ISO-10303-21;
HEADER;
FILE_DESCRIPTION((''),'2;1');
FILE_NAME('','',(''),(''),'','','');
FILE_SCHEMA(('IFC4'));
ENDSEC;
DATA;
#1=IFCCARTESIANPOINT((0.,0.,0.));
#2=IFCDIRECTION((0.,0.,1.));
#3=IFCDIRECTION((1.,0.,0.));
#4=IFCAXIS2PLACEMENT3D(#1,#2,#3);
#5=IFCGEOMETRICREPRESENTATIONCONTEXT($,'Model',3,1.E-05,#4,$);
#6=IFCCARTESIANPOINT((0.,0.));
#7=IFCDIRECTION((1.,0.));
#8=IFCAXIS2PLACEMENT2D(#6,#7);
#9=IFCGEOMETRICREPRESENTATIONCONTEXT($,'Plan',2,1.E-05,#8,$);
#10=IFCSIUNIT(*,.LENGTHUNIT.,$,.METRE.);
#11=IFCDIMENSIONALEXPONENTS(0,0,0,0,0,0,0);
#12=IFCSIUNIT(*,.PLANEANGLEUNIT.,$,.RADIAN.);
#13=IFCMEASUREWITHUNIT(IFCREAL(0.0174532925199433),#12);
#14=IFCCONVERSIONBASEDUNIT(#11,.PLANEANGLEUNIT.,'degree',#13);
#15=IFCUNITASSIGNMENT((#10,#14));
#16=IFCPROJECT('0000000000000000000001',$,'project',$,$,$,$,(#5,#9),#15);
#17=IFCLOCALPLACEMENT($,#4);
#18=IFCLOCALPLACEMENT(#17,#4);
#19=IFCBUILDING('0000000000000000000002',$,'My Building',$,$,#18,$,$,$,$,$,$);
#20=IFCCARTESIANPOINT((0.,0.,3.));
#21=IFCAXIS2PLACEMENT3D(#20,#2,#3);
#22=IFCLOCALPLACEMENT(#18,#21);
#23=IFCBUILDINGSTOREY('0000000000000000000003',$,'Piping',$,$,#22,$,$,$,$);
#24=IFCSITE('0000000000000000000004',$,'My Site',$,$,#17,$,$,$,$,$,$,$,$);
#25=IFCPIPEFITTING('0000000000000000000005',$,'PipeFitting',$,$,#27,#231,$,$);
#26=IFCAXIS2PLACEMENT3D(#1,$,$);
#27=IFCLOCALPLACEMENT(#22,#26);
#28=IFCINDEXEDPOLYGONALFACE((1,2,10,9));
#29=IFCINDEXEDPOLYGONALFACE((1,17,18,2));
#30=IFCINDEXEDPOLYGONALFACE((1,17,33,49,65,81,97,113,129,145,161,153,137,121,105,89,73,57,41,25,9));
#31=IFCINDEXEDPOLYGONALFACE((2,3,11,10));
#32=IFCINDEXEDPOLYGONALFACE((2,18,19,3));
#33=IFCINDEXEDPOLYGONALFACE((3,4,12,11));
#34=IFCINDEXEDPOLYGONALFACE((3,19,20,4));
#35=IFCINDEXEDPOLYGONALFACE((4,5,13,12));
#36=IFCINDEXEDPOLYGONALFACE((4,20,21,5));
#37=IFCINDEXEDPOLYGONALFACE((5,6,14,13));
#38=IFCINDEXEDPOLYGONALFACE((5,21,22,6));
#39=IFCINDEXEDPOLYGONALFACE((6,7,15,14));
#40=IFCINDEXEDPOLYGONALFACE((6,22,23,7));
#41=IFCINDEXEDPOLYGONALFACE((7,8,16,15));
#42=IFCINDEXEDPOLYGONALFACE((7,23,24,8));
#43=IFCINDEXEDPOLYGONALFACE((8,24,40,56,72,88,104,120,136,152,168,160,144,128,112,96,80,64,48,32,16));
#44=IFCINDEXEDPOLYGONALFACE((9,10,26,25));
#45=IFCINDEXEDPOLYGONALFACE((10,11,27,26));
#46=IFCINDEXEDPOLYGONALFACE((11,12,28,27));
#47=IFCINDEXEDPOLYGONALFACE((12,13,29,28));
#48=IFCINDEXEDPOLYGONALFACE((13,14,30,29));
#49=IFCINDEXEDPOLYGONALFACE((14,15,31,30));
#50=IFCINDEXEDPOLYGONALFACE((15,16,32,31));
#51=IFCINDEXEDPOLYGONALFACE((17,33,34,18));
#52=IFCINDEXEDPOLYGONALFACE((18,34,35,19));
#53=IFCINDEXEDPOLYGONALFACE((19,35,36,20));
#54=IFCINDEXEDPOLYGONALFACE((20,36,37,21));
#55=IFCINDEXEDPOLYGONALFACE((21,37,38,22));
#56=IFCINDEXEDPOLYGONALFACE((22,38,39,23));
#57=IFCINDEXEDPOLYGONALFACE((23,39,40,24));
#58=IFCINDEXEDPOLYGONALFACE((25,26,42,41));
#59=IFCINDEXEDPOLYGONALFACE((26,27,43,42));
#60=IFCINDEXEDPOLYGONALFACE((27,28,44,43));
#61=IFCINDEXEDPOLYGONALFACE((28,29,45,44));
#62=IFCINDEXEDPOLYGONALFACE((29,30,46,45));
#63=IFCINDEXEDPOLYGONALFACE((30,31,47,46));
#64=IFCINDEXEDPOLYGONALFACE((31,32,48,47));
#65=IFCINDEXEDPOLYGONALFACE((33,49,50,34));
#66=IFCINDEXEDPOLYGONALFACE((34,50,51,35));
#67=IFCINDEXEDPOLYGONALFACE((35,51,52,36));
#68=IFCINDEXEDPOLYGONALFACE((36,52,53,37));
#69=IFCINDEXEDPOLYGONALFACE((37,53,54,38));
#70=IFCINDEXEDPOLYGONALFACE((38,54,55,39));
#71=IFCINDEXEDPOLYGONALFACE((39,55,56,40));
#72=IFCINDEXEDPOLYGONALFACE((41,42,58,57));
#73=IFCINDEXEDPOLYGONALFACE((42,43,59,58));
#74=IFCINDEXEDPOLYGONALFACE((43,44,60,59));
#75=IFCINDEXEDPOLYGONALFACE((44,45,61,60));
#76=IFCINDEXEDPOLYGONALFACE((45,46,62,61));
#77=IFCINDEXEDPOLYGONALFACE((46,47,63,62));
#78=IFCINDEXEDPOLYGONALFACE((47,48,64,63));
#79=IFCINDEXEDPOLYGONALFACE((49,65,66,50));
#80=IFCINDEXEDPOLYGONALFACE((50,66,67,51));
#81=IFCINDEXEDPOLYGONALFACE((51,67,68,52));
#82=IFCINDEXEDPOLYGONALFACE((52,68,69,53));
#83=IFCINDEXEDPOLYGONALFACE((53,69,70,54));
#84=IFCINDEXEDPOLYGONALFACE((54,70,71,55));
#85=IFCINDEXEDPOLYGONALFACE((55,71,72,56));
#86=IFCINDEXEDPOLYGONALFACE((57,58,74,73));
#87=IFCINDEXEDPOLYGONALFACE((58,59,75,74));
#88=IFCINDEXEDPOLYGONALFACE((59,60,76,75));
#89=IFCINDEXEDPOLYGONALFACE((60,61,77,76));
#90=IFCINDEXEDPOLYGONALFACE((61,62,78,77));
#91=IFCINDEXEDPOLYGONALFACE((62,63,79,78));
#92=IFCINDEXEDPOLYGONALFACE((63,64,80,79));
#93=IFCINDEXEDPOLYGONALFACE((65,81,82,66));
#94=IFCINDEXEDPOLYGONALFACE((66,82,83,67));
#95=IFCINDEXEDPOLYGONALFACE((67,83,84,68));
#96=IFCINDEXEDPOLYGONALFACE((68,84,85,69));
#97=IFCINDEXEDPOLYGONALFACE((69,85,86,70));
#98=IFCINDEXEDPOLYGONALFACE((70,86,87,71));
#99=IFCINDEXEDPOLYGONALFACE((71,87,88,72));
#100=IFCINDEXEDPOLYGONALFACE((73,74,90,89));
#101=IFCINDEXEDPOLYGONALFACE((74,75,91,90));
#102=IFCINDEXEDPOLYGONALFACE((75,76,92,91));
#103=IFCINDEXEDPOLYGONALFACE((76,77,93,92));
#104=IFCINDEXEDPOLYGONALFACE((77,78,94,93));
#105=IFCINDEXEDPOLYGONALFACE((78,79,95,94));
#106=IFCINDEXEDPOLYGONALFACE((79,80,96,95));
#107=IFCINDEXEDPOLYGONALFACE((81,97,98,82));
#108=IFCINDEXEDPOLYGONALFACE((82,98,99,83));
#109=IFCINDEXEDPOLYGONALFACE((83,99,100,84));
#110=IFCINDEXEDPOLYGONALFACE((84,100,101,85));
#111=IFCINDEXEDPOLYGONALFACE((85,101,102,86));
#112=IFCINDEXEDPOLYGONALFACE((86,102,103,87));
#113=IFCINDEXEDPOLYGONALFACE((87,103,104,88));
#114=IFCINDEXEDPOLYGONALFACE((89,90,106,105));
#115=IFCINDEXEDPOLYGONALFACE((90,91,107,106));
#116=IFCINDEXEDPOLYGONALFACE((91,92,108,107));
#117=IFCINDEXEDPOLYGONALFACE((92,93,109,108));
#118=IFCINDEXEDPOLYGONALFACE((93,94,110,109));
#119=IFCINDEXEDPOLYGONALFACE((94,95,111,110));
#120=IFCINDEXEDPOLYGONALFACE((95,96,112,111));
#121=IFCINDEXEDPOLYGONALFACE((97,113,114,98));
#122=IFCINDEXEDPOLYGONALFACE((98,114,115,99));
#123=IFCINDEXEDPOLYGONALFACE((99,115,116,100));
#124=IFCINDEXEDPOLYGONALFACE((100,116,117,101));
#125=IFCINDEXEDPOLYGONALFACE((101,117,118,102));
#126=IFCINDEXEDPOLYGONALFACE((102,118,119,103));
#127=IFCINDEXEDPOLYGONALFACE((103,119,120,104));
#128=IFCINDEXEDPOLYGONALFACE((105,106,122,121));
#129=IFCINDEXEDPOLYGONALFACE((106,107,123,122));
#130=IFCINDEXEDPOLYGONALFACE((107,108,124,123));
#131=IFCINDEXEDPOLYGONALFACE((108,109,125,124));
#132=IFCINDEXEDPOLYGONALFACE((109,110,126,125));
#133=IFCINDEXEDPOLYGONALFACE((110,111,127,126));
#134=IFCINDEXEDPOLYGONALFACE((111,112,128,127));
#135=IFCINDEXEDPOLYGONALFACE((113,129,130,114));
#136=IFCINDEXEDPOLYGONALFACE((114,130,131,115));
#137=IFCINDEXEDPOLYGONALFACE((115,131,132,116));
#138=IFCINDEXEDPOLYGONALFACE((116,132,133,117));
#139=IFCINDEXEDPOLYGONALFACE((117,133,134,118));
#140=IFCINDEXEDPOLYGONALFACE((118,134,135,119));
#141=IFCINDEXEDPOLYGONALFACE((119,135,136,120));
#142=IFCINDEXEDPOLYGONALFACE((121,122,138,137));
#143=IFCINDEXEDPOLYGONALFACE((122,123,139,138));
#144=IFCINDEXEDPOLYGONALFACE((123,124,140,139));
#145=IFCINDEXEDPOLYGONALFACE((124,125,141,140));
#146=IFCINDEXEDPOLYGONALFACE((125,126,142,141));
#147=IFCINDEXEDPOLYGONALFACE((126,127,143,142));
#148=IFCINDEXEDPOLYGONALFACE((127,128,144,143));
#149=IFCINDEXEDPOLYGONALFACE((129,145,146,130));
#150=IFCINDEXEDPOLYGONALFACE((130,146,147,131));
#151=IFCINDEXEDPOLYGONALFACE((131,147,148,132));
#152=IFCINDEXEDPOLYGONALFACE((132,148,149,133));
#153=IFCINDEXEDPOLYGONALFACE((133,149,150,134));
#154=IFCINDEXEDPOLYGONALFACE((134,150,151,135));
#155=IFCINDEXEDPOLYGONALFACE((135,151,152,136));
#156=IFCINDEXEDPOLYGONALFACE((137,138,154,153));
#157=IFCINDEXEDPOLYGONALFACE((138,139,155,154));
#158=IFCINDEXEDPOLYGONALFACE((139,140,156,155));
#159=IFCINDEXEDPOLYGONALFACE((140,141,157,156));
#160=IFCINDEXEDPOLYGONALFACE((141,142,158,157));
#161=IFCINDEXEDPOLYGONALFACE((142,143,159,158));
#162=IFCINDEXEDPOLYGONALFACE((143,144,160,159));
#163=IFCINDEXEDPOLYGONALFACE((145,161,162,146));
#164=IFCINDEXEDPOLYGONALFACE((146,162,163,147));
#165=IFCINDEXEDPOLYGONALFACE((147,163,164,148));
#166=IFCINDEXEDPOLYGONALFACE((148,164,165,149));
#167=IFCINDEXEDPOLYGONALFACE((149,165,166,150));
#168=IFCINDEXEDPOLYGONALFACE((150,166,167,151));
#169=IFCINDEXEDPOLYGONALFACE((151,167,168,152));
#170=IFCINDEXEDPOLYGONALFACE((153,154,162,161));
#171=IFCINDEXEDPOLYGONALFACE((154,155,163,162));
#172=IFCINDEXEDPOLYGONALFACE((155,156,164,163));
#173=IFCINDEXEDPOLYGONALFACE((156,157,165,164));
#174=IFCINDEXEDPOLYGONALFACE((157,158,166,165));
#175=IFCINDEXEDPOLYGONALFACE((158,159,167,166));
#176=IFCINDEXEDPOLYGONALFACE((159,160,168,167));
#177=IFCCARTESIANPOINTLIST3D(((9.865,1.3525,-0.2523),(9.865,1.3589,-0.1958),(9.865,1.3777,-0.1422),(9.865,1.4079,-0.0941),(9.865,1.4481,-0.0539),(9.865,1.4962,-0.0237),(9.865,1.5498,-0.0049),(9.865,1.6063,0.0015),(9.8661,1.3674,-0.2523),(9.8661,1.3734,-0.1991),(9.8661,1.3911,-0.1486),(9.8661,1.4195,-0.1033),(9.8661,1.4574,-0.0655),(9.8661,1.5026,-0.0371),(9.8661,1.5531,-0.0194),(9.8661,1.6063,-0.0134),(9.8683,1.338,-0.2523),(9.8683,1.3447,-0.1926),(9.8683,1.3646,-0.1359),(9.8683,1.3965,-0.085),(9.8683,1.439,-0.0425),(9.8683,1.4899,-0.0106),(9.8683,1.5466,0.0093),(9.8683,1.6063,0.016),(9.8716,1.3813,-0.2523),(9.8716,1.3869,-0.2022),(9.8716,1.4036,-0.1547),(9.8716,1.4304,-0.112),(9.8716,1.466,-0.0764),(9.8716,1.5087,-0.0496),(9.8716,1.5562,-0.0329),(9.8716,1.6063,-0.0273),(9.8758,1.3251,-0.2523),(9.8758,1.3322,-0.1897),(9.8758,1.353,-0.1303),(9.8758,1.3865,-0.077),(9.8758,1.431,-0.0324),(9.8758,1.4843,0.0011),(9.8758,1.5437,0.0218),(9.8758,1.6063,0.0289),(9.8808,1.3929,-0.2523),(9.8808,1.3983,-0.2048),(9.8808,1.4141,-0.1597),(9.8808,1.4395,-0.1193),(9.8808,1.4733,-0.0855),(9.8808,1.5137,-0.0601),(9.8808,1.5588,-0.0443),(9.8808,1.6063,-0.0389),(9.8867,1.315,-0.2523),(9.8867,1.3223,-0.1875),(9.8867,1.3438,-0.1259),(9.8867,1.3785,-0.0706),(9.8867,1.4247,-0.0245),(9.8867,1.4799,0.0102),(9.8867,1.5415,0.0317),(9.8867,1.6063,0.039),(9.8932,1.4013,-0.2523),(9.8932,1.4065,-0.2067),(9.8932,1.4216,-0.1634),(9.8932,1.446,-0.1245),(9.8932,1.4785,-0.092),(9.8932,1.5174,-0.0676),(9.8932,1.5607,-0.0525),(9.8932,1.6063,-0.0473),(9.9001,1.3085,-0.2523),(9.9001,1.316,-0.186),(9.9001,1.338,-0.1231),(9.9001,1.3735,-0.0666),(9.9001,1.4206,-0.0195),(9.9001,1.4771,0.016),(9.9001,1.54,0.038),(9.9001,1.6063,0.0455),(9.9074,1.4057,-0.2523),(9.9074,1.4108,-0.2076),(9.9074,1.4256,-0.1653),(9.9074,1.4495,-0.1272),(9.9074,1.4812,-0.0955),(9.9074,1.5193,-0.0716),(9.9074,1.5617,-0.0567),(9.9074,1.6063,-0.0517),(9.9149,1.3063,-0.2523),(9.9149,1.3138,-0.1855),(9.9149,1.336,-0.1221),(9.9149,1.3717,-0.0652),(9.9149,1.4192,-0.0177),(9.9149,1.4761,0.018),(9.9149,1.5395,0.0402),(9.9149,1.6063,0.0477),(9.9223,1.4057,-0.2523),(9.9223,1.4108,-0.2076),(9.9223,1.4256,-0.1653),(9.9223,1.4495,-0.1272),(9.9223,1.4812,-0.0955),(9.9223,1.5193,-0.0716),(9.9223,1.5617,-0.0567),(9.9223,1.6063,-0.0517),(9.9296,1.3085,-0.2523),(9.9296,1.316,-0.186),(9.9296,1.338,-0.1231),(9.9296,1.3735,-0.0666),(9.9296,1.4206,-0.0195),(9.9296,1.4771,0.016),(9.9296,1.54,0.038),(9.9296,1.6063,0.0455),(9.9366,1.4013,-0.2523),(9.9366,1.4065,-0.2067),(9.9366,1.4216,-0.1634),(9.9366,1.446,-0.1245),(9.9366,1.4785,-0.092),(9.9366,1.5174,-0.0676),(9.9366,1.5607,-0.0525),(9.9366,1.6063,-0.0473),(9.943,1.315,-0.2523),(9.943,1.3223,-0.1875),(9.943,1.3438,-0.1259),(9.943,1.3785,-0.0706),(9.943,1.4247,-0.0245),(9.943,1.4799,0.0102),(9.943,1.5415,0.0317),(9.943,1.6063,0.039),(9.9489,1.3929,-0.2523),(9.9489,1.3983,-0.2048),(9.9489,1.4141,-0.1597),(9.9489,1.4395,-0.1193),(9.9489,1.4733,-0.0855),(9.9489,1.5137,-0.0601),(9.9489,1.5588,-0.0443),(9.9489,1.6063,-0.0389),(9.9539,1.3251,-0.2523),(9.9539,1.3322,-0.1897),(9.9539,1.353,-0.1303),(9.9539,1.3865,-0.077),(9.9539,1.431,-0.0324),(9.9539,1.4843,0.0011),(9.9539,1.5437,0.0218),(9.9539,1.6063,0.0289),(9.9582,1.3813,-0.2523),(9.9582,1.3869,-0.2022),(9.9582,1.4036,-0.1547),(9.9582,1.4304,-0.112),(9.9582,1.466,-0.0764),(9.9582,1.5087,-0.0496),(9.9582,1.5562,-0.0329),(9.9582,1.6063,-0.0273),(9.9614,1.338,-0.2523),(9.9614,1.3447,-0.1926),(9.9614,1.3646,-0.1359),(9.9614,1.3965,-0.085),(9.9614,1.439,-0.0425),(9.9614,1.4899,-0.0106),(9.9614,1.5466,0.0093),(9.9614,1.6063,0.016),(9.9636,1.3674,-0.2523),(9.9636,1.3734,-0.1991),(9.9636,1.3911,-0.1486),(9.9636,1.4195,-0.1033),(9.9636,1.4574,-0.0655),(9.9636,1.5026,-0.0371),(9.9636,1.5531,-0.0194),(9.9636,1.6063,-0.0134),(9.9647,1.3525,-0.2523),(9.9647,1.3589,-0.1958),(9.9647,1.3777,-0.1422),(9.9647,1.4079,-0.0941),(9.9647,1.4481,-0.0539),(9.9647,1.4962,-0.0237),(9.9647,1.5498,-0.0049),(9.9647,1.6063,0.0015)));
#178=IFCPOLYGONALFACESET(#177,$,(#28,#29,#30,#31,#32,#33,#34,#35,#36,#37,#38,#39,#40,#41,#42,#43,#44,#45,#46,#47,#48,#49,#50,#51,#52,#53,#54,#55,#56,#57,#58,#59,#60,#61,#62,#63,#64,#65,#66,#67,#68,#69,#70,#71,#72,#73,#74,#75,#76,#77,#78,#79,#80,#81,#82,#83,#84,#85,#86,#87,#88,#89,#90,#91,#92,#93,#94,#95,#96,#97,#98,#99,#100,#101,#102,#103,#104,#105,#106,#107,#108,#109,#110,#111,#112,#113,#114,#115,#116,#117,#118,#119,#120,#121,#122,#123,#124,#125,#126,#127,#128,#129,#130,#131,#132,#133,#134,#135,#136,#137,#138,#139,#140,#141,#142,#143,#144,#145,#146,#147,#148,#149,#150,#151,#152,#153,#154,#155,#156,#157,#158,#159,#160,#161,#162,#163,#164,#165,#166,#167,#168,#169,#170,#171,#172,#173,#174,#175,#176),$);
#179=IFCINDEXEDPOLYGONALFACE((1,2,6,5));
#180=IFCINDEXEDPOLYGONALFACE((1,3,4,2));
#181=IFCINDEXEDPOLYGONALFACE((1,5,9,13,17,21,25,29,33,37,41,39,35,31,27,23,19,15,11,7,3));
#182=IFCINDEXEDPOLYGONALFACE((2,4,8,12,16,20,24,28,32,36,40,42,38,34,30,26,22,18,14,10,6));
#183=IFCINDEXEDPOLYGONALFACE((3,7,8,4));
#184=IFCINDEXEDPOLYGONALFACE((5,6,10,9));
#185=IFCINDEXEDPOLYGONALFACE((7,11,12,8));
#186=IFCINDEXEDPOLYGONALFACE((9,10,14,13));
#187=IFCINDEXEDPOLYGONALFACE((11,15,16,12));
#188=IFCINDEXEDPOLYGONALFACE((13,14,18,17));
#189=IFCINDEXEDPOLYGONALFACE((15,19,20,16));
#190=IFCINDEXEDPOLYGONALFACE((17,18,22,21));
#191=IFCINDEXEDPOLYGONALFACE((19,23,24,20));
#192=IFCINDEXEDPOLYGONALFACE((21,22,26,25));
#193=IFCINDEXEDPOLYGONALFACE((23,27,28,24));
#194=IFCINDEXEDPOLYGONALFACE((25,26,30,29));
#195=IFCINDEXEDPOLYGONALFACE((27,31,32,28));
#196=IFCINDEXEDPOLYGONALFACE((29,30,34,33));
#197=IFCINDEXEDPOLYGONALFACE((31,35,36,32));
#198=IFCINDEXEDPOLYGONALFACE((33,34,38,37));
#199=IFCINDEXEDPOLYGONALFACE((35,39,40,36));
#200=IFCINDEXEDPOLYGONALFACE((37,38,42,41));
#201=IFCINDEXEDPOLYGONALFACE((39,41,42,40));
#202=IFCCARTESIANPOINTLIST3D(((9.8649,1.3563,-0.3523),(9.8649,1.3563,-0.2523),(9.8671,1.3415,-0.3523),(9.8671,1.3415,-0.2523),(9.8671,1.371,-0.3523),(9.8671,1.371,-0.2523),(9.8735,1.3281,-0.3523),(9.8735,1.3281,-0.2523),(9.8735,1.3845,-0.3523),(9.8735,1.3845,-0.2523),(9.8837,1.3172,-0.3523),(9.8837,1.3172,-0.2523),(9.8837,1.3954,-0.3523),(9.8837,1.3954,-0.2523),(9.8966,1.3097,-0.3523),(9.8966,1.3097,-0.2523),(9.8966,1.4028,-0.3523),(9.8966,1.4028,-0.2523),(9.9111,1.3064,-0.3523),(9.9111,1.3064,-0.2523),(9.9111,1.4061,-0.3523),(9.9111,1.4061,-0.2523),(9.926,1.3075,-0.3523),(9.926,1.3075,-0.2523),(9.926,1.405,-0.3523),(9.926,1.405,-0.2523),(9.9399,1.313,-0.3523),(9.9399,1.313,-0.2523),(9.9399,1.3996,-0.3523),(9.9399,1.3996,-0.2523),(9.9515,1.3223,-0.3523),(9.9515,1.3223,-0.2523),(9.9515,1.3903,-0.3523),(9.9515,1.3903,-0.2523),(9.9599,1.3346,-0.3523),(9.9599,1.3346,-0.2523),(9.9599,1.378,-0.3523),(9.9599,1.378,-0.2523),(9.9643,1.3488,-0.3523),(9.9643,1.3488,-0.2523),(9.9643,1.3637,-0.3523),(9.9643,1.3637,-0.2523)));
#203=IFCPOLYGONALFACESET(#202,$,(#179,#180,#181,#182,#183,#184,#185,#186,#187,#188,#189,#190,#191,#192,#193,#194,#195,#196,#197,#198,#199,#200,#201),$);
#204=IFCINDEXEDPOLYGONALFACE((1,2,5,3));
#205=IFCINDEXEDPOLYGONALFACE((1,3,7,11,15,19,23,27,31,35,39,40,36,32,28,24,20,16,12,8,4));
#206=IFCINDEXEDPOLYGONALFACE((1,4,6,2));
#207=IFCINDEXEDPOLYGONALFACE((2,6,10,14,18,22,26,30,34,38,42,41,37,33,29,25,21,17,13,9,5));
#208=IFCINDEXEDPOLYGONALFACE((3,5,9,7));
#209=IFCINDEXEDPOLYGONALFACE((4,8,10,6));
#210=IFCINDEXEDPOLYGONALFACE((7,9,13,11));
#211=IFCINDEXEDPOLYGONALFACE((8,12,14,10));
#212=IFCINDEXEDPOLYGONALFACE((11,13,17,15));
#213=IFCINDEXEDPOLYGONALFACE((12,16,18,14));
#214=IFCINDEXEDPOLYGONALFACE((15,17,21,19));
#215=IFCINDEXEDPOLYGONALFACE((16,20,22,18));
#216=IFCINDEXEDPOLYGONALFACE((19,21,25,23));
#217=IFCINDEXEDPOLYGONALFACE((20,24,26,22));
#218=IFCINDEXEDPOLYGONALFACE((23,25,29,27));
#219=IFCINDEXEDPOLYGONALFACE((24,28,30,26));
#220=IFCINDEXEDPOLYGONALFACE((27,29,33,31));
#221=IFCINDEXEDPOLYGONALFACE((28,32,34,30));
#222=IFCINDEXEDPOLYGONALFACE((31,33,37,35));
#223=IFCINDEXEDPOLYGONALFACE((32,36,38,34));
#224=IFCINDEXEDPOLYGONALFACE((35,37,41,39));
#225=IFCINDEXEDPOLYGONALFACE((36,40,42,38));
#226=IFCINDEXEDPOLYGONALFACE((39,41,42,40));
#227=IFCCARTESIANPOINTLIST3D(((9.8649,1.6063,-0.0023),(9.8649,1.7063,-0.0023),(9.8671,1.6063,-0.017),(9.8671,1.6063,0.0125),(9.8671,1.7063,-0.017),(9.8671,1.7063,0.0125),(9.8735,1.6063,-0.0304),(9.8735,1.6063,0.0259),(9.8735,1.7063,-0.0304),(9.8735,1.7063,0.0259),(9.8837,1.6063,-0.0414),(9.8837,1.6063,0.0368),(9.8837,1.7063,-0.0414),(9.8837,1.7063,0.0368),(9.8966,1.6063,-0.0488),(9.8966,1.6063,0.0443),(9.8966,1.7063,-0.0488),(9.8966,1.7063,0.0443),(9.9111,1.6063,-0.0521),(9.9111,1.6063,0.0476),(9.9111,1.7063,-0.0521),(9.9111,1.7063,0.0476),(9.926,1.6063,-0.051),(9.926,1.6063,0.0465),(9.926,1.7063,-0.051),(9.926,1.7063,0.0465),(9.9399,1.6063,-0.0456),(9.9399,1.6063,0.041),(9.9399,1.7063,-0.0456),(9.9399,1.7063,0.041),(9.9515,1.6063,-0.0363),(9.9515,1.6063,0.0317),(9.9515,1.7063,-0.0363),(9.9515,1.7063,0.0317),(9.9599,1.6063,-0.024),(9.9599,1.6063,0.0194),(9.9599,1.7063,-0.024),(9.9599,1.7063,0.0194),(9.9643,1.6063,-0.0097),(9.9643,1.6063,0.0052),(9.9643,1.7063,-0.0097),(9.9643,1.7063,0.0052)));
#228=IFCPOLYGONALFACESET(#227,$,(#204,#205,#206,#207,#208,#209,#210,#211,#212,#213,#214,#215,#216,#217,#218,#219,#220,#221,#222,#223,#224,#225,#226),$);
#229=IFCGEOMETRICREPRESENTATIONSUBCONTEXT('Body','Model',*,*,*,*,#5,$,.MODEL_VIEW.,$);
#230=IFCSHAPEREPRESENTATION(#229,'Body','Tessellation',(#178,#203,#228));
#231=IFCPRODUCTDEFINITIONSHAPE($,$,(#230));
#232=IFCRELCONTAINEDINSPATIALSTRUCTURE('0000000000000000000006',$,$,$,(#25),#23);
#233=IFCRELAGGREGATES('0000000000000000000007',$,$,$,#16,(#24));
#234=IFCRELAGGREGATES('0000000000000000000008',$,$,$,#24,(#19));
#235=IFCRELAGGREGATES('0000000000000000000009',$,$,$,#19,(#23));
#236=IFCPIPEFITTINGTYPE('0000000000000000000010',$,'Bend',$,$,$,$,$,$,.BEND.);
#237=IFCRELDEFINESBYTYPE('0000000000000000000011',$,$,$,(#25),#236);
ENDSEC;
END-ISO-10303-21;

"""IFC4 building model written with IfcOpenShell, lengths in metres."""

from ifc_helpers import new_model, entity, si_unit, converted_unit, frame, origin_with_axes, origin_2d_with_axis, place, context, subcontext, project, spatial, circle, extrude, source, transform, mapped, type_object, type_shapes, element, save


model = new_model("IFC4")

# Units and contexts
model_context = context("Model", 3, precision=1e-05, world=origin_with_axes())
plan_context = context("Plan", 2, precision=1e-05, world=origin_2d_with_axis())
body_context = subcontext(model_context, "Body", "Model", "MODEL_VIEW")
ifc_project = project(units=[si_unit("LENGTHUNIT", "METRE"), converted_unit("PLANEANGLEUNIT", "degree", entity("IfcReal", 0.0174532925199433), si_unit("PLANEANGLEUNIT", "RADIAN"), dimensions=[0, 0, 0, 0, 0, 0, 0])], contexts=[model_context, plan_context])

# Site, building, storey
site_placement = place(None, origin_with_axes())
site = spatial("IfcSite", under=ifc_project, at=site_placement, Name="My Site")
building_placement = place(site_placement, origin_with_axes())
building = spatial("IfcBuilding", under=site, at=building_placement, Name="My Building")
storey_placement = place(building_placement, frame((0.0, 0.0, 3.0), z_axis=(0.0, 0.0, 1.0), x_axis=(1.0, 0.0, 0.0)))
storey = spatial("IfcBuildingStorey", under=building, at=storey_placement, Name="Piping")

# Pipe fitting
pipe_fitting_type_1 = type_object("IfcPipeFittingType", Name="Bend", PredefinedType="BEND")
shared_shape = source(origin_with_axes(), body_context, "Body", "SolidModel", [
    entity("IfcSweptDiskSolid", entity("IfcIndexedPolyCurve", entity("IfcCartesianPointList3D", [[0.0, 0.0, -0.1], [0.0, 0.0732, -0.2768], [0.0, 0.25, -0.35]]), [entity("IfcArcIndex", [1, 2, 3])]), 0.05),
    extrude(circle(Radius=0.05), origin_with_axes(), (0.0, 0.0, -1.0), 0.1),
    extrude(circle(Radius=0.05), frame((0.0, 0.25, -0.35), z_axis=(0.0, 1.0, 0.0), x_axis=(1.0, 0.0, 0.0)), (0.0, 0.0, 1.0), 0.1),
])
type_shapes(pipe_fitting_type_1, [shared_shape])
for number, where, z_axis, x_axis, name in (
    (1, (9.9149, 1.3563, -0.3523), (0.0, 0.0, -1.0), (-1.0, 0.0, 0.0), "PipeFitting"),
):
    element("IfcPipeFitting", number, at=place(storey_placement, frame(where, z_axis=z_axis, x_axis=x_axis)), inside=storey, type_object=pipe_fitting_type_1, Name=name, context=body_context, shape_type="MappedRepresentation", body=[
        mapped(shared_shape, transform((0.0, 0.0, 0.0), x_axis=(1.0, 0.0, 0.0), y_axis=(0.0, 1.0, 0.0), z_axis=(0.0, 0.0, 1.0), scale=1.0)),
    ])

save(model, "model.ifc")
